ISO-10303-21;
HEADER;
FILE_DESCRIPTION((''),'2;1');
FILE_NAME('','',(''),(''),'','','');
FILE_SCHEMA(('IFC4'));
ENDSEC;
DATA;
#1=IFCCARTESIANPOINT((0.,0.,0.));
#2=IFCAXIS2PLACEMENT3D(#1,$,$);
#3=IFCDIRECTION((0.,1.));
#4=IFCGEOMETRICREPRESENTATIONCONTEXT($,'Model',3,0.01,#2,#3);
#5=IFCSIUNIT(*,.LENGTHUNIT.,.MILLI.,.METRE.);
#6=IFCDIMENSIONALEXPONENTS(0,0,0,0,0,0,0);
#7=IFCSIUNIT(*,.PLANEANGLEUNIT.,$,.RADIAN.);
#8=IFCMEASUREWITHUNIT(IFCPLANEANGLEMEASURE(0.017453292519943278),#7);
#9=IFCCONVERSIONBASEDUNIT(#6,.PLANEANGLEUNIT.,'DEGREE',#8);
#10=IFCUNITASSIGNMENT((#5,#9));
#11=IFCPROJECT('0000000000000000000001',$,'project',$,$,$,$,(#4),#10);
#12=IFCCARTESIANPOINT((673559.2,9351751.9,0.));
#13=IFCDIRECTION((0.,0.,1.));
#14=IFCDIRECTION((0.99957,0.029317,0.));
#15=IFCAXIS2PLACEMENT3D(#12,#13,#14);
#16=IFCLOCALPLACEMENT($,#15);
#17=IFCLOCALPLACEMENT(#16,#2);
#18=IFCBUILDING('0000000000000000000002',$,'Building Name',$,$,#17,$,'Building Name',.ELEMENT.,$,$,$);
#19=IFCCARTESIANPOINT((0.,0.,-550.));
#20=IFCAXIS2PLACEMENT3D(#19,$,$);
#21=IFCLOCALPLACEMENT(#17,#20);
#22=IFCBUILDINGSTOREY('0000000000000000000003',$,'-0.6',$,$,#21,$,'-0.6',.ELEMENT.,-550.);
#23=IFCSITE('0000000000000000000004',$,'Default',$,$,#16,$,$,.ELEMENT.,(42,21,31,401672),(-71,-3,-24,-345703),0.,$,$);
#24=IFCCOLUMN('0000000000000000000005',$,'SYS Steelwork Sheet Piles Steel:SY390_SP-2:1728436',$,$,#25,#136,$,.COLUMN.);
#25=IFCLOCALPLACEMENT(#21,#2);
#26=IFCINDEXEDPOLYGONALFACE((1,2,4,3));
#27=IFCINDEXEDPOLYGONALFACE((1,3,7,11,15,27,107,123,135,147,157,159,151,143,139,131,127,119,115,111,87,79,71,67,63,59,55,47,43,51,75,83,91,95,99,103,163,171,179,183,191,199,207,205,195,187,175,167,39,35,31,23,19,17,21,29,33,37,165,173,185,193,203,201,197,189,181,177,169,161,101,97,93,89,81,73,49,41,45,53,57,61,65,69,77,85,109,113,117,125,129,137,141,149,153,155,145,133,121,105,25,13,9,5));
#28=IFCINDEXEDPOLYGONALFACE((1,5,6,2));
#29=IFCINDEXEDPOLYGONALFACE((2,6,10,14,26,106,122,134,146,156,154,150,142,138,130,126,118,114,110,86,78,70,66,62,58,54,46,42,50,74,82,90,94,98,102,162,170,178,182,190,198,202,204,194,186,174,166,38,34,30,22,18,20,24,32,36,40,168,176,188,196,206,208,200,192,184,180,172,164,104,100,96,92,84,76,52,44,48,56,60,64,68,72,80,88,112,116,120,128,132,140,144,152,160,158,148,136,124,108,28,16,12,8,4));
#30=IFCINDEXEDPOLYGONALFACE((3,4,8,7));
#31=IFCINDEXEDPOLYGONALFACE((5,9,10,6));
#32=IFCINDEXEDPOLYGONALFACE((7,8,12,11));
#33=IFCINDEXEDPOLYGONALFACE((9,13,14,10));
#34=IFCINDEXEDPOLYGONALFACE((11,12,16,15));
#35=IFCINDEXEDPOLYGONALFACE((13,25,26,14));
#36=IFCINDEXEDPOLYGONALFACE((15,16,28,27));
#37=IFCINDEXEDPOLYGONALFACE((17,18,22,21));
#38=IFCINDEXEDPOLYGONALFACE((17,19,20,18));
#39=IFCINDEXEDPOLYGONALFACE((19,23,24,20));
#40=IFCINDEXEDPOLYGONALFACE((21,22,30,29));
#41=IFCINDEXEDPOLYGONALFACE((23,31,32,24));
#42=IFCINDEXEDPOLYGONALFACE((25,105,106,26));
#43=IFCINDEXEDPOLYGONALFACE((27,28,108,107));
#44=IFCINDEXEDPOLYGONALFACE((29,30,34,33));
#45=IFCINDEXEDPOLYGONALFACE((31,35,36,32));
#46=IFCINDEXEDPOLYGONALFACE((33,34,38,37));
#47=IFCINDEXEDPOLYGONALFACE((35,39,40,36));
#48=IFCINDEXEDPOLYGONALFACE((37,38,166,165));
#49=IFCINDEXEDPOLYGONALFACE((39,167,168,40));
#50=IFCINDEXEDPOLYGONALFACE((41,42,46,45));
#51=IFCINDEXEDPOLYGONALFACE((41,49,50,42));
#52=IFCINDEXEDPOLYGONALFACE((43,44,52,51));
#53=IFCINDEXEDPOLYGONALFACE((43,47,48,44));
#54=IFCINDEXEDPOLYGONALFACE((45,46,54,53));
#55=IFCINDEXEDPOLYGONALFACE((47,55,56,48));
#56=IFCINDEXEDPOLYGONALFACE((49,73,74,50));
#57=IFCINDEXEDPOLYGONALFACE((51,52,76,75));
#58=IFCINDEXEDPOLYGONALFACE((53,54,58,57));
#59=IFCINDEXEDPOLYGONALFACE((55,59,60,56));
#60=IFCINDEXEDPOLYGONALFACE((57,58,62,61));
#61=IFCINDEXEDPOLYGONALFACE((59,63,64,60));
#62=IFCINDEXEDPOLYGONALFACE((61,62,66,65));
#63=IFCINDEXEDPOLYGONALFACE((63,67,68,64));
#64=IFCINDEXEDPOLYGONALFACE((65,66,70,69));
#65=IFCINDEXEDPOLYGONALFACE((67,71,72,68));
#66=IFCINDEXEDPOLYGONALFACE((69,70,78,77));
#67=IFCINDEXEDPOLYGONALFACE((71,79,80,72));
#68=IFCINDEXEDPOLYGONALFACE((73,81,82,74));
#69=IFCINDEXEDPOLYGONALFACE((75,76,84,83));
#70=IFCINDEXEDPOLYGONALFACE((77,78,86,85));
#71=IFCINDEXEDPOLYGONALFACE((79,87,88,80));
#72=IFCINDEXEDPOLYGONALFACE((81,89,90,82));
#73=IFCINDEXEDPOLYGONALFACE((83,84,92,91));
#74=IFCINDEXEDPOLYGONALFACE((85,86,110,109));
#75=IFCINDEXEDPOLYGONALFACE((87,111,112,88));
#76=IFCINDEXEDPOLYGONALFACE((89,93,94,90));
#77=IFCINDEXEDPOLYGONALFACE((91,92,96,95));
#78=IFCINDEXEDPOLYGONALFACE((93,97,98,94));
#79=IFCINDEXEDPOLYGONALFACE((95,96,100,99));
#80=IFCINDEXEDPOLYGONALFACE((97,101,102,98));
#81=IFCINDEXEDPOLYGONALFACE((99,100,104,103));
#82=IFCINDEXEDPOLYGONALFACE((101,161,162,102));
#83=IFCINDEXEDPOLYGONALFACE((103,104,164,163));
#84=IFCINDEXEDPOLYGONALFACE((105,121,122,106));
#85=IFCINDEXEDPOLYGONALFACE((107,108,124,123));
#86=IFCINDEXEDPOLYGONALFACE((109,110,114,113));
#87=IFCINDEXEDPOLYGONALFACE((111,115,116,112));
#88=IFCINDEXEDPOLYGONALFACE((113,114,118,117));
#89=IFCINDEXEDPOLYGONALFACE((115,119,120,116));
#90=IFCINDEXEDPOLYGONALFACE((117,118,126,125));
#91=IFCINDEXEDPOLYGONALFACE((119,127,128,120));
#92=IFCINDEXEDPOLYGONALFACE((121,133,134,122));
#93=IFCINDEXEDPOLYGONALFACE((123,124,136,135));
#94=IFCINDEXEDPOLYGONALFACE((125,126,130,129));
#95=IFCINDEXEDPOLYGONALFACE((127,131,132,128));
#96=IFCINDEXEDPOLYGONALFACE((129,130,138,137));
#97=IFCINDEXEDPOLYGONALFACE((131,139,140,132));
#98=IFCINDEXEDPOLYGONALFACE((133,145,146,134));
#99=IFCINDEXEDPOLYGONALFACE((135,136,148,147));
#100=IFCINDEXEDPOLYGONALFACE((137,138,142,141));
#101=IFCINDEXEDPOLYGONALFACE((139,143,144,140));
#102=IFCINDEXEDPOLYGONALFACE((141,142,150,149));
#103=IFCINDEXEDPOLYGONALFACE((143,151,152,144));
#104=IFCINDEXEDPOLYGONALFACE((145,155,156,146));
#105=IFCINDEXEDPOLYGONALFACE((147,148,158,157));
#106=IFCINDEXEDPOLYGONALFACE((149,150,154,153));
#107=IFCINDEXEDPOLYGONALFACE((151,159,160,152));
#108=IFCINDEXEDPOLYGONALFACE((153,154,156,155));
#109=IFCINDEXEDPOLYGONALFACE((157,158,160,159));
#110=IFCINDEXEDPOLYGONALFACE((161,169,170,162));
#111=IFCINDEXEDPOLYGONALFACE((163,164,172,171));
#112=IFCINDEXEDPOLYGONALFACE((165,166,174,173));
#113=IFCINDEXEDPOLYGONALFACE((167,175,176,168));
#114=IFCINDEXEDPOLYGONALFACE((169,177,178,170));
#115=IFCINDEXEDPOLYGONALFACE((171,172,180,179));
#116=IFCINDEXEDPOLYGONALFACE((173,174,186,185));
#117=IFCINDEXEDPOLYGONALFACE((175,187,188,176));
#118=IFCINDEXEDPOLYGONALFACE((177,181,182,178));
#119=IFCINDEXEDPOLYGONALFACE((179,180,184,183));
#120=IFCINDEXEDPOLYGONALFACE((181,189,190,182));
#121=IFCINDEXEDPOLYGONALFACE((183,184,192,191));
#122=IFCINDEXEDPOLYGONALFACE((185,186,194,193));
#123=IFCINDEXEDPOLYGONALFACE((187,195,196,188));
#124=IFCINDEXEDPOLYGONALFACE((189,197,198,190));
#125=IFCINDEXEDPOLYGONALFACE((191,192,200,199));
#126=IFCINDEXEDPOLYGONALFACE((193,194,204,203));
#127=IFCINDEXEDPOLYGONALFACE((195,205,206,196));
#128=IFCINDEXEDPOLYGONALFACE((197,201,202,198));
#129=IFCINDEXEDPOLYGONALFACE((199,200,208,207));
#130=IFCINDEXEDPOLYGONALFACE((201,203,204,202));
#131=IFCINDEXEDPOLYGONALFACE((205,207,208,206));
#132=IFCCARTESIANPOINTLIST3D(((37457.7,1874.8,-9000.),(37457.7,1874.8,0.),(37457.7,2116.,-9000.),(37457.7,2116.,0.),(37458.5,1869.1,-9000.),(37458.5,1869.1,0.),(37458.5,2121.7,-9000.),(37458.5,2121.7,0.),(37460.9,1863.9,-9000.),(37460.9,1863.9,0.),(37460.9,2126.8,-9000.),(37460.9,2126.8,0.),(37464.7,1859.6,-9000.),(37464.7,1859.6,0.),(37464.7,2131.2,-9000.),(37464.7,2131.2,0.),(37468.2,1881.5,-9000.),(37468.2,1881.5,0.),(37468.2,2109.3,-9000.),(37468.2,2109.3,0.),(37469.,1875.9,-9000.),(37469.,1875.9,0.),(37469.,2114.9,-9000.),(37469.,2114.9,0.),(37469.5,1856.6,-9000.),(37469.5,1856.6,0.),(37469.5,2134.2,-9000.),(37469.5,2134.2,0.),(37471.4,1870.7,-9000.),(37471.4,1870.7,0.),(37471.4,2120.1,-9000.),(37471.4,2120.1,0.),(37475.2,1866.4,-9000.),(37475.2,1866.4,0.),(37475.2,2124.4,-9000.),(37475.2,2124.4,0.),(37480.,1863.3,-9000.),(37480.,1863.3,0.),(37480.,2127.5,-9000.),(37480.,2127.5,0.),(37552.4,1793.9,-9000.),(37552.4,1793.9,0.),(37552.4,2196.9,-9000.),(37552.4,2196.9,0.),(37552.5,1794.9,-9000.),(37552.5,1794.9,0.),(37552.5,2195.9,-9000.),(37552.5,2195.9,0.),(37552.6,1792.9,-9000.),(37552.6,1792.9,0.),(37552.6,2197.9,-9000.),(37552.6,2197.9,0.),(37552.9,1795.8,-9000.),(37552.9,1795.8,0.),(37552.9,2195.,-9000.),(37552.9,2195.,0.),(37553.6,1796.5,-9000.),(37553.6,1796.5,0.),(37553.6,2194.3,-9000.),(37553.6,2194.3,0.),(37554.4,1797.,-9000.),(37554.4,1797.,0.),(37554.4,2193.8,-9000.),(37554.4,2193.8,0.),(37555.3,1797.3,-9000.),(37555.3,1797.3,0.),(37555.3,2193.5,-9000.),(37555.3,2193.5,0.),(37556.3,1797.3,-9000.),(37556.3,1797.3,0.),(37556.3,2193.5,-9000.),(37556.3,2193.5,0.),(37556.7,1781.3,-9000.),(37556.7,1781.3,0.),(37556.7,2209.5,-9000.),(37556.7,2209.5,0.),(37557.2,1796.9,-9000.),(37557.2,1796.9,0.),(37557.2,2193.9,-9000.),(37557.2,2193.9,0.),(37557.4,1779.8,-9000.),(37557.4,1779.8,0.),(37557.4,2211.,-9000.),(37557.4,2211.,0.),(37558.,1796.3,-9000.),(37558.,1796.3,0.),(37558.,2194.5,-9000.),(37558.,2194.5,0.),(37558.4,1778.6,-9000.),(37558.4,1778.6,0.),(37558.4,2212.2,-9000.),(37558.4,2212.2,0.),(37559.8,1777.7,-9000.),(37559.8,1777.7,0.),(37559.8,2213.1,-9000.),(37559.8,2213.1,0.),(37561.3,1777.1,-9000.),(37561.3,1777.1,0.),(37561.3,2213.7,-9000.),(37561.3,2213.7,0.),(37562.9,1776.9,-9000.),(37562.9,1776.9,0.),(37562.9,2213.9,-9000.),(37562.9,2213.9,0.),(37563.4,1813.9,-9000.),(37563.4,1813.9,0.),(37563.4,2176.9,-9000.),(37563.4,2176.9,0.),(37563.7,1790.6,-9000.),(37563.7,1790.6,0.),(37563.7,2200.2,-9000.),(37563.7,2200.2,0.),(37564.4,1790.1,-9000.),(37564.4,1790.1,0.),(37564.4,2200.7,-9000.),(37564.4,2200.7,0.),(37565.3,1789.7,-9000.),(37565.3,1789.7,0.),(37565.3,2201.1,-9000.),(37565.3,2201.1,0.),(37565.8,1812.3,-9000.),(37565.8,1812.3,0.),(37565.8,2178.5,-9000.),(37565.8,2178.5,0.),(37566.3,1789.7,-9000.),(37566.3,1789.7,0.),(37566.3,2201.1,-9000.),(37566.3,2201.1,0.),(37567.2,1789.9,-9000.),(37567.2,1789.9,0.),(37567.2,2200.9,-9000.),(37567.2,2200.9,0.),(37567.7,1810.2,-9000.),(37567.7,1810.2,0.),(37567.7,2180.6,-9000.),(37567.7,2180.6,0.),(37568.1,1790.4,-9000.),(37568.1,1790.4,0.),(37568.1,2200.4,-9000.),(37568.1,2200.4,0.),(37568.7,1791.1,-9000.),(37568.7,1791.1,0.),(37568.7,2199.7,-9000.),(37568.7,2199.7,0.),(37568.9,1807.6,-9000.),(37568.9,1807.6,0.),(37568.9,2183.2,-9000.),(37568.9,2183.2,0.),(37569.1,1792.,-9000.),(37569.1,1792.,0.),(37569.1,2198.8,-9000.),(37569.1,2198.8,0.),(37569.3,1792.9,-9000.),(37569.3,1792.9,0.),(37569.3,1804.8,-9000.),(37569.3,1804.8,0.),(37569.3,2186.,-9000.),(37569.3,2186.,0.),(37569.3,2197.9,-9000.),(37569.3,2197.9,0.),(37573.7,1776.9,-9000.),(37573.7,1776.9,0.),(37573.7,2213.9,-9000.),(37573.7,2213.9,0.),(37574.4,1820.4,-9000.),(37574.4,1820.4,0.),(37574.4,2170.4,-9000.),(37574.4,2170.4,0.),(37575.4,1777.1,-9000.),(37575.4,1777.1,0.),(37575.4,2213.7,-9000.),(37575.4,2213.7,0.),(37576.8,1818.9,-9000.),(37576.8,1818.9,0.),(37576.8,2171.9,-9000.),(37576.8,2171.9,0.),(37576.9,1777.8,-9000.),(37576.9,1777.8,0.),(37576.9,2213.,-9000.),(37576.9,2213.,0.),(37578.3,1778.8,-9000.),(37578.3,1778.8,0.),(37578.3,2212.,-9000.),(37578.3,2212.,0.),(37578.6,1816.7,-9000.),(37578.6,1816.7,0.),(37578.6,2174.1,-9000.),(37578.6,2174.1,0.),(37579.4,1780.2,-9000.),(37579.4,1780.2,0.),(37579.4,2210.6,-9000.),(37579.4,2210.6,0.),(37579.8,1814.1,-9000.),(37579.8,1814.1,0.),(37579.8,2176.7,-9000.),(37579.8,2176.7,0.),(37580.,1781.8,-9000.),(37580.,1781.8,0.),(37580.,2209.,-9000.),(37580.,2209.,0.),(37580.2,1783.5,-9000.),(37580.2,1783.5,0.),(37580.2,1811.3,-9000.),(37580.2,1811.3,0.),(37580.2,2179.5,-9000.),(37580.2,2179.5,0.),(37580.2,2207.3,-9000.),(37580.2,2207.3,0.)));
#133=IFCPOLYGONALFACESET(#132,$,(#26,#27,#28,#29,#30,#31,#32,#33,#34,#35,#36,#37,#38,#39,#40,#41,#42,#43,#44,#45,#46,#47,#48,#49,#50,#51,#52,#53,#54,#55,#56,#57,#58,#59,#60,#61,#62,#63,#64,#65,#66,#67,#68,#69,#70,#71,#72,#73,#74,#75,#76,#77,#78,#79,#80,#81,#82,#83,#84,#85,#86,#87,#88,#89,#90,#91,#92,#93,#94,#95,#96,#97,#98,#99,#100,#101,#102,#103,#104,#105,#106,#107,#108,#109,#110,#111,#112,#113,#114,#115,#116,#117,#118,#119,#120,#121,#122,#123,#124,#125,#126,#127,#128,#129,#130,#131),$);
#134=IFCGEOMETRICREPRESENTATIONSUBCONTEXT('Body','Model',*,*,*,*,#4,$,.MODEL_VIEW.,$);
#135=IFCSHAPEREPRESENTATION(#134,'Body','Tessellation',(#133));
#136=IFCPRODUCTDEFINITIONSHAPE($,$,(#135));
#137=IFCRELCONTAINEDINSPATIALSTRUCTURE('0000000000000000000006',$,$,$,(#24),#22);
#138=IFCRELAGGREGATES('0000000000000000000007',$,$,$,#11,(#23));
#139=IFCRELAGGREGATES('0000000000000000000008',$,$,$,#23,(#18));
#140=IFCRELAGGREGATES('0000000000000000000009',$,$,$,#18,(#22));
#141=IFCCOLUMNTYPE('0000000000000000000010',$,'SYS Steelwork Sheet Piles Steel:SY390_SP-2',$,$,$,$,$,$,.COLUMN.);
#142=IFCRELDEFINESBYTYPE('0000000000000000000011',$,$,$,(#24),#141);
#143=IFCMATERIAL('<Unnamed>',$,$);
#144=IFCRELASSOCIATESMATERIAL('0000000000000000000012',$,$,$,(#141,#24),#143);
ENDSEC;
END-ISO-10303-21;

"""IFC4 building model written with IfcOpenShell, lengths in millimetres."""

from ifc_helpers import new_model, entity, si_unit, converted_unit, direction, frame, origin, place, context, subcontext, project, spatial, line, arc, indexed_curve, outline, extrude, source, transform, mapped, material, type_object, type_shapes, element, save


model = new_model("IFC4")

# Units and contexts
model_context = context("Model", 3, precision=0.01, world=origin(), true_north=direction((0.0, 1.0)))
body_context = subcontext(model_context, "Body", "Model", "MODEL_VIEW")
ifc_project = project(units=[si_unit("LENGTHUNIT", "METRE", prefix="MILLI"), converted_unit("PLANEANGLEUNIT", "DEGREE", entity("IfcPlaneAngleMeasure", 0.017453292519943278), si_unit("PLANEANGLEUNIT", "RADIAN"), dimensions=[0, 0, 0, 0, 0, 0, 0])], contexts=[model_context])

# Site, building, storey
site_placement = place(None, frame((673559.2, 9351751.9, 0.0), z_axis=(0.0, 0.0, 1.0), x_axis=(0.99957, 0.029317, 0.0)))
site = spatial("IfcSite", under=ifc_project, at=site_placement, Name="Default", CompositionType="ELEMENT", RefLatitude=(42, 21, 31, 401672), RefLongitude=(-71, -3, -24, -345703), RefElevation=0.0)
building_placement = place(site_placement, origin())
building = spatial("IfcBuilding", under=site, at=building_placement, Name="Building Name", LongName="Building Name", CompositionType="ELEMENT")
storey_placement = place(building_placement, frame((0.0, 0.0, -550.0)))
storey = spatial("IfcBuildingStorey", under=building, at=storey_placement, Name="-0.6", LongName="-0.6", CompositionType="ELEMENT", Elevation=-550.0)

# Column
ifc_material_1 = material(Name="<Unnamed>")
column_type = type_object("IfcColumnType", Name="SYS Steelwork Sheet Piles Steel:SY390_SP-2", PredefinedType="COLUMN", material=ifc_material_1)
shared_shape = source(origin(), body_context, "Body", "SweptSolid", [
    extrude(outline(indexed_curve([(-120.6, 84.7), (-131.4, 81.6), (-138.8, 73.0), (-181.5, -20.9), (-185.2, -25.2), (-190.6, -26.8), (-202.5, -26.8), (-205.5, -24.8), (-204.8, -21.2), (-199.1, -15.5), (-198.6, -11.5), (-202.5, -10.1), (-214.1, -14.2), (-217.3, -16.6), (-218.5, -20.4), (-218.5, -31.2), (-216.6, -35.8), (-211.9, -37.8), (-184.1, -37.8), (-178.7, -36.2), (-175.0, -31.9), (-132.1, 62.5), (-124.7, 71.1), (-113.9, 74.2), (113.9, 74.2), (124.7, 71.1), (132.1, 62.5), (175.0, -31.9), (178.7, -36.2), (184.1, -37.8), (211.9, -37.8), (216.6, -35.8), (218.5, -31.2), (218.5, -20.4), (217.3, -16.6), (214.1, -14.2), (202.5, -10.1), (198.6, -11.5), (199.1, -15.5), (204.8, -21.2), (205.5, -24.8), (202.5, -26.8), (190.6, -26.8), (185.2, -25.2), (181.5, -20.9), (138.8, 73.0), (131.4, 81.6), (120.6, 84.7)], segments=[arc(1, 2, 3), line(3, 4), arc(4, 5, 6), line(6, 7), arc(7, 8, 9), line(9, 10), arc(10, 11, 12), line(12, 13), arc(13, 14, 15), line(15, 16), arc(16, 17, 18), line(18, 19), arc(19, 20, 21), line(21, 22), arc(22, 23, 24), line(24, 25), arc(25, 26, 27), line(27, 28), arc(28, 29, 30), line(30, 31), arc(31, 32, 33), line(33, 34), arc(34, 35, 36), line(36, 37), arc(37, 38, 39), line(39, 40), arc(40, 41, 42), line(42, 43), arc(43, 44, 45), line(45, 46), arc(46, 47, 48), line(48, 1)], self_intersect=False)), frame((0.0, 15.3, -9550.0)), (0.0, 0.0, 1.0), 9000.0),
])
type_shapes(column_type, [shared_shape])
for number, where, z_axis, x_axis, name in (
    (1, (37557.7, 1995.4, 550.0), (0.0, 0.0, 1.0), (0.0, 1.0, 0.0), "SYS Steelwork Sheet Piles Steel:SY390_SP-2:1728436"),
):
    element("IfcColumn", number, at=place(storey_placement, frame(where, z_axis=z_axis, x_axis=x_axis)), inside=storey, type_object=column_type, material=ifc_material_1, Name=name, PredefinedType="COLUMN", context=body_context, shape_type="MappedRepresentation", body=[
        mapped(shared_shape, transform((0.0, 0.0, 0.0), scale=1.0)),
    ])

save(model, "model.ifc")
